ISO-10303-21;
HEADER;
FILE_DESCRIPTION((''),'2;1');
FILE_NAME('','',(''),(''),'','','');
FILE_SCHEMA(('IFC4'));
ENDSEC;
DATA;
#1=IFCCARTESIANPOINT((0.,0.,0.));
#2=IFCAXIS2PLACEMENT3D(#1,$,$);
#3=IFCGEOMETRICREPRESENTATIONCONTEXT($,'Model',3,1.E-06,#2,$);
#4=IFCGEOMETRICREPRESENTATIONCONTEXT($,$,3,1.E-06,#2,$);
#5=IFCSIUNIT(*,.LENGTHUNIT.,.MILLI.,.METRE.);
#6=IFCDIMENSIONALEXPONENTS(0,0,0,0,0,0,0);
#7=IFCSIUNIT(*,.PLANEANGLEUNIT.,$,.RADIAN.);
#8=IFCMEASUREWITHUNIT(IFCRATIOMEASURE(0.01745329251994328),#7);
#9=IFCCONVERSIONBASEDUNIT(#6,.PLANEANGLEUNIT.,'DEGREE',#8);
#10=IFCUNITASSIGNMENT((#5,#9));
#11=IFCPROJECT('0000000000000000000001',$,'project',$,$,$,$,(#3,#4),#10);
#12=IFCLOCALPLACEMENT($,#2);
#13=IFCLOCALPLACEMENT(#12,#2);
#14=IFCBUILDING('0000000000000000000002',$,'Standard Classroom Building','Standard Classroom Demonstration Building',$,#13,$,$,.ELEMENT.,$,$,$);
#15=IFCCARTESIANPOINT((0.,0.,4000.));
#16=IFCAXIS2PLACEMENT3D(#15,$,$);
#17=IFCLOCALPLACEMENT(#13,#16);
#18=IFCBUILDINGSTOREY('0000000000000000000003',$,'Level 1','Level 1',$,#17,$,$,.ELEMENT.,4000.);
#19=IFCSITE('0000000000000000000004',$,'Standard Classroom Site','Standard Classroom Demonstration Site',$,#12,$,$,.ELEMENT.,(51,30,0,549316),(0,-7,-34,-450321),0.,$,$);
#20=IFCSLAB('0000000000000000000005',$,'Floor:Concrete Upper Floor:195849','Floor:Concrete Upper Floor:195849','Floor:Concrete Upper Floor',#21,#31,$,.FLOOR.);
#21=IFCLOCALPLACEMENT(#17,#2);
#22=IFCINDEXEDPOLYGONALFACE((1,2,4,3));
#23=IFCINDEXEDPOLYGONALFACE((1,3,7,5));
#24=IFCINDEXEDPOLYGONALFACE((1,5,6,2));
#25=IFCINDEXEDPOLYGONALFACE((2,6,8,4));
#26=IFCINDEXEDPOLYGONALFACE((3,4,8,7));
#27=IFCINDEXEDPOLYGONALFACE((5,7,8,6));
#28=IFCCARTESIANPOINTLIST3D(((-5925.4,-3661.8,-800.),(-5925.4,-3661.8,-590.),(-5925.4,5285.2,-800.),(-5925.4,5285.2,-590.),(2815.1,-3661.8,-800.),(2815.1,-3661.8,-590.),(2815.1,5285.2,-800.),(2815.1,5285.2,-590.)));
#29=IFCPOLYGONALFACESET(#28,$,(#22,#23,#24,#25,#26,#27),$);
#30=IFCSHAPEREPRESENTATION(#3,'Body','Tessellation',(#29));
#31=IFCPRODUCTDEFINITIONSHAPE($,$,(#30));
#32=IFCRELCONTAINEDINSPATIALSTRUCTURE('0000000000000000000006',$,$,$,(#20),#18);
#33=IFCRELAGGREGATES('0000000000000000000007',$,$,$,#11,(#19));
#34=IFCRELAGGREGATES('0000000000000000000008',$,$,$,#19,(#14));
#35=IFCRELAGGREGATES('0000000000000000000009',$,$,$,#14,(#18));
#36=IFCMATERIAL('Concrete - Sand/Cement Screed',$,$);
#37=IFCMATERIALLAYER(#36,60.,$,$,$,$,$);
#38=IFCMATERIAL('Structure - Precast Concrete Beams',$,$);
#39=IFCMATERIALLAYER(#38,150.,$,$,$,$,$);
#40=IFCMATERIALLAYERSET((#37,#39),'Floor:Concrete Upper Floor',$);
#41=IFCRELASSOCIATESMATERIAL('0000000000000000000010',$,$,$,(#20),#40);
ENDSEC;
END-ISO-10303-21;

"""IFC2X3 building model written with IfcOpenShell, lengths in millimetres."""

from ifc_helpers import new_model, entity, si_unit, converted_unit, frame, frame_2d, origin, place, context, project, spatial, rectangle, extrude, material, layer, layer_set, layer_usage, element, save


model = new_model("IFC2X3")

# Units and contexts
model_context = context("Model", 3, precision=1e-06, world=origin())
context_of_model = context(None, 3, precision=1e-06, world=origin())
ifc_project = project(units=[si_unit("LENGTHUNIT", "METRE", prefix="MILLI"), converted_unit("PLANEANGLEUNIT", "DEGREE", entity("IfcRatioMeasure", 0.01745329251994328), si_unit("PLANEANGLEUNIT", "RADIAN"), dimensions=[0, 0, 0, 0, 0, 0, 0])], contexts=[model_context, context_of_model])

# Site, building, storey
site_placement = place(None, origin())
site = spatial("IfcSite", under=ifc_project, at=site_placement, Name="Standard Classroom Site", Description="Standard Classroom Demonstration Site", CompositionType="ELEMENT", RefLatitude=(51, 30, 0, 549316), RefLongitude=(0, -7, -34, -450321), RefElevation=0.0)
building_placement = place(site_placement, origin())
building = spatial("IfcBuilding", under=site, at=building_placement, Name="Standard Classroom Building", Description="Standard Classroom Demonstration Building", CompositionType="ELEMENT")
storey_placement = place(building_placement, frame((0.0, 0.0, 4000.0)))
storey = spatial("IfcBuildingStorey", under=building, at=storey_placement, Name="Level 1", Description="Level 1", CompositionType="ELEMENT", Elevation=4000.0)

# Slab
ifc_material_1 = material(Name="Concrete - Sand/Cement Screed")
ifc_layer_1 = layer(ifc_material_1, 60.0)
ifc_material_2 = material(Name="Structure - Precast Concrete Beams")
ifc_layer_2 = layer(ifc_material_2, 150.0)
ifc_layer_set = layer_set([ifc_layer_1, ifc_layer_2], Name="Floor:Concrete Upper Floor")
ifc_layer_usage = layer_usage(ifc_layer_set, "AXIS3", "POSITIVE", 0.0)
slab_placement = place(storey_placement, frame((-5925.4, -3661.8, -800.0)))
element("IfcSlab", 1, at=slab_placement, inside=storey, material=ifc_layer_usage, Name="Floor:Concrete Upper Floor:195849", Description="Floor:Concrete Upper Floor:195849", ObjectType="Floor:Concrete Upper Floor", PredefinedType="FLOOR", context=model_context, shape_type="SweptSolid", body=[
    extrude(rectangle(XDim=8947.0, YDim=8740.5, at=frame_2d((0.0, 0.0), x_axis=(0.0, -1.0))), frame((4370.3, 4473.5, 210.0), z_axis=(0.0, 0.0, -1.0), x_axis=(-1.0, 0.0, 0.0)), (0.0, 0.0, 1.0), 210.0),
])

save(model, "model.ifc")
